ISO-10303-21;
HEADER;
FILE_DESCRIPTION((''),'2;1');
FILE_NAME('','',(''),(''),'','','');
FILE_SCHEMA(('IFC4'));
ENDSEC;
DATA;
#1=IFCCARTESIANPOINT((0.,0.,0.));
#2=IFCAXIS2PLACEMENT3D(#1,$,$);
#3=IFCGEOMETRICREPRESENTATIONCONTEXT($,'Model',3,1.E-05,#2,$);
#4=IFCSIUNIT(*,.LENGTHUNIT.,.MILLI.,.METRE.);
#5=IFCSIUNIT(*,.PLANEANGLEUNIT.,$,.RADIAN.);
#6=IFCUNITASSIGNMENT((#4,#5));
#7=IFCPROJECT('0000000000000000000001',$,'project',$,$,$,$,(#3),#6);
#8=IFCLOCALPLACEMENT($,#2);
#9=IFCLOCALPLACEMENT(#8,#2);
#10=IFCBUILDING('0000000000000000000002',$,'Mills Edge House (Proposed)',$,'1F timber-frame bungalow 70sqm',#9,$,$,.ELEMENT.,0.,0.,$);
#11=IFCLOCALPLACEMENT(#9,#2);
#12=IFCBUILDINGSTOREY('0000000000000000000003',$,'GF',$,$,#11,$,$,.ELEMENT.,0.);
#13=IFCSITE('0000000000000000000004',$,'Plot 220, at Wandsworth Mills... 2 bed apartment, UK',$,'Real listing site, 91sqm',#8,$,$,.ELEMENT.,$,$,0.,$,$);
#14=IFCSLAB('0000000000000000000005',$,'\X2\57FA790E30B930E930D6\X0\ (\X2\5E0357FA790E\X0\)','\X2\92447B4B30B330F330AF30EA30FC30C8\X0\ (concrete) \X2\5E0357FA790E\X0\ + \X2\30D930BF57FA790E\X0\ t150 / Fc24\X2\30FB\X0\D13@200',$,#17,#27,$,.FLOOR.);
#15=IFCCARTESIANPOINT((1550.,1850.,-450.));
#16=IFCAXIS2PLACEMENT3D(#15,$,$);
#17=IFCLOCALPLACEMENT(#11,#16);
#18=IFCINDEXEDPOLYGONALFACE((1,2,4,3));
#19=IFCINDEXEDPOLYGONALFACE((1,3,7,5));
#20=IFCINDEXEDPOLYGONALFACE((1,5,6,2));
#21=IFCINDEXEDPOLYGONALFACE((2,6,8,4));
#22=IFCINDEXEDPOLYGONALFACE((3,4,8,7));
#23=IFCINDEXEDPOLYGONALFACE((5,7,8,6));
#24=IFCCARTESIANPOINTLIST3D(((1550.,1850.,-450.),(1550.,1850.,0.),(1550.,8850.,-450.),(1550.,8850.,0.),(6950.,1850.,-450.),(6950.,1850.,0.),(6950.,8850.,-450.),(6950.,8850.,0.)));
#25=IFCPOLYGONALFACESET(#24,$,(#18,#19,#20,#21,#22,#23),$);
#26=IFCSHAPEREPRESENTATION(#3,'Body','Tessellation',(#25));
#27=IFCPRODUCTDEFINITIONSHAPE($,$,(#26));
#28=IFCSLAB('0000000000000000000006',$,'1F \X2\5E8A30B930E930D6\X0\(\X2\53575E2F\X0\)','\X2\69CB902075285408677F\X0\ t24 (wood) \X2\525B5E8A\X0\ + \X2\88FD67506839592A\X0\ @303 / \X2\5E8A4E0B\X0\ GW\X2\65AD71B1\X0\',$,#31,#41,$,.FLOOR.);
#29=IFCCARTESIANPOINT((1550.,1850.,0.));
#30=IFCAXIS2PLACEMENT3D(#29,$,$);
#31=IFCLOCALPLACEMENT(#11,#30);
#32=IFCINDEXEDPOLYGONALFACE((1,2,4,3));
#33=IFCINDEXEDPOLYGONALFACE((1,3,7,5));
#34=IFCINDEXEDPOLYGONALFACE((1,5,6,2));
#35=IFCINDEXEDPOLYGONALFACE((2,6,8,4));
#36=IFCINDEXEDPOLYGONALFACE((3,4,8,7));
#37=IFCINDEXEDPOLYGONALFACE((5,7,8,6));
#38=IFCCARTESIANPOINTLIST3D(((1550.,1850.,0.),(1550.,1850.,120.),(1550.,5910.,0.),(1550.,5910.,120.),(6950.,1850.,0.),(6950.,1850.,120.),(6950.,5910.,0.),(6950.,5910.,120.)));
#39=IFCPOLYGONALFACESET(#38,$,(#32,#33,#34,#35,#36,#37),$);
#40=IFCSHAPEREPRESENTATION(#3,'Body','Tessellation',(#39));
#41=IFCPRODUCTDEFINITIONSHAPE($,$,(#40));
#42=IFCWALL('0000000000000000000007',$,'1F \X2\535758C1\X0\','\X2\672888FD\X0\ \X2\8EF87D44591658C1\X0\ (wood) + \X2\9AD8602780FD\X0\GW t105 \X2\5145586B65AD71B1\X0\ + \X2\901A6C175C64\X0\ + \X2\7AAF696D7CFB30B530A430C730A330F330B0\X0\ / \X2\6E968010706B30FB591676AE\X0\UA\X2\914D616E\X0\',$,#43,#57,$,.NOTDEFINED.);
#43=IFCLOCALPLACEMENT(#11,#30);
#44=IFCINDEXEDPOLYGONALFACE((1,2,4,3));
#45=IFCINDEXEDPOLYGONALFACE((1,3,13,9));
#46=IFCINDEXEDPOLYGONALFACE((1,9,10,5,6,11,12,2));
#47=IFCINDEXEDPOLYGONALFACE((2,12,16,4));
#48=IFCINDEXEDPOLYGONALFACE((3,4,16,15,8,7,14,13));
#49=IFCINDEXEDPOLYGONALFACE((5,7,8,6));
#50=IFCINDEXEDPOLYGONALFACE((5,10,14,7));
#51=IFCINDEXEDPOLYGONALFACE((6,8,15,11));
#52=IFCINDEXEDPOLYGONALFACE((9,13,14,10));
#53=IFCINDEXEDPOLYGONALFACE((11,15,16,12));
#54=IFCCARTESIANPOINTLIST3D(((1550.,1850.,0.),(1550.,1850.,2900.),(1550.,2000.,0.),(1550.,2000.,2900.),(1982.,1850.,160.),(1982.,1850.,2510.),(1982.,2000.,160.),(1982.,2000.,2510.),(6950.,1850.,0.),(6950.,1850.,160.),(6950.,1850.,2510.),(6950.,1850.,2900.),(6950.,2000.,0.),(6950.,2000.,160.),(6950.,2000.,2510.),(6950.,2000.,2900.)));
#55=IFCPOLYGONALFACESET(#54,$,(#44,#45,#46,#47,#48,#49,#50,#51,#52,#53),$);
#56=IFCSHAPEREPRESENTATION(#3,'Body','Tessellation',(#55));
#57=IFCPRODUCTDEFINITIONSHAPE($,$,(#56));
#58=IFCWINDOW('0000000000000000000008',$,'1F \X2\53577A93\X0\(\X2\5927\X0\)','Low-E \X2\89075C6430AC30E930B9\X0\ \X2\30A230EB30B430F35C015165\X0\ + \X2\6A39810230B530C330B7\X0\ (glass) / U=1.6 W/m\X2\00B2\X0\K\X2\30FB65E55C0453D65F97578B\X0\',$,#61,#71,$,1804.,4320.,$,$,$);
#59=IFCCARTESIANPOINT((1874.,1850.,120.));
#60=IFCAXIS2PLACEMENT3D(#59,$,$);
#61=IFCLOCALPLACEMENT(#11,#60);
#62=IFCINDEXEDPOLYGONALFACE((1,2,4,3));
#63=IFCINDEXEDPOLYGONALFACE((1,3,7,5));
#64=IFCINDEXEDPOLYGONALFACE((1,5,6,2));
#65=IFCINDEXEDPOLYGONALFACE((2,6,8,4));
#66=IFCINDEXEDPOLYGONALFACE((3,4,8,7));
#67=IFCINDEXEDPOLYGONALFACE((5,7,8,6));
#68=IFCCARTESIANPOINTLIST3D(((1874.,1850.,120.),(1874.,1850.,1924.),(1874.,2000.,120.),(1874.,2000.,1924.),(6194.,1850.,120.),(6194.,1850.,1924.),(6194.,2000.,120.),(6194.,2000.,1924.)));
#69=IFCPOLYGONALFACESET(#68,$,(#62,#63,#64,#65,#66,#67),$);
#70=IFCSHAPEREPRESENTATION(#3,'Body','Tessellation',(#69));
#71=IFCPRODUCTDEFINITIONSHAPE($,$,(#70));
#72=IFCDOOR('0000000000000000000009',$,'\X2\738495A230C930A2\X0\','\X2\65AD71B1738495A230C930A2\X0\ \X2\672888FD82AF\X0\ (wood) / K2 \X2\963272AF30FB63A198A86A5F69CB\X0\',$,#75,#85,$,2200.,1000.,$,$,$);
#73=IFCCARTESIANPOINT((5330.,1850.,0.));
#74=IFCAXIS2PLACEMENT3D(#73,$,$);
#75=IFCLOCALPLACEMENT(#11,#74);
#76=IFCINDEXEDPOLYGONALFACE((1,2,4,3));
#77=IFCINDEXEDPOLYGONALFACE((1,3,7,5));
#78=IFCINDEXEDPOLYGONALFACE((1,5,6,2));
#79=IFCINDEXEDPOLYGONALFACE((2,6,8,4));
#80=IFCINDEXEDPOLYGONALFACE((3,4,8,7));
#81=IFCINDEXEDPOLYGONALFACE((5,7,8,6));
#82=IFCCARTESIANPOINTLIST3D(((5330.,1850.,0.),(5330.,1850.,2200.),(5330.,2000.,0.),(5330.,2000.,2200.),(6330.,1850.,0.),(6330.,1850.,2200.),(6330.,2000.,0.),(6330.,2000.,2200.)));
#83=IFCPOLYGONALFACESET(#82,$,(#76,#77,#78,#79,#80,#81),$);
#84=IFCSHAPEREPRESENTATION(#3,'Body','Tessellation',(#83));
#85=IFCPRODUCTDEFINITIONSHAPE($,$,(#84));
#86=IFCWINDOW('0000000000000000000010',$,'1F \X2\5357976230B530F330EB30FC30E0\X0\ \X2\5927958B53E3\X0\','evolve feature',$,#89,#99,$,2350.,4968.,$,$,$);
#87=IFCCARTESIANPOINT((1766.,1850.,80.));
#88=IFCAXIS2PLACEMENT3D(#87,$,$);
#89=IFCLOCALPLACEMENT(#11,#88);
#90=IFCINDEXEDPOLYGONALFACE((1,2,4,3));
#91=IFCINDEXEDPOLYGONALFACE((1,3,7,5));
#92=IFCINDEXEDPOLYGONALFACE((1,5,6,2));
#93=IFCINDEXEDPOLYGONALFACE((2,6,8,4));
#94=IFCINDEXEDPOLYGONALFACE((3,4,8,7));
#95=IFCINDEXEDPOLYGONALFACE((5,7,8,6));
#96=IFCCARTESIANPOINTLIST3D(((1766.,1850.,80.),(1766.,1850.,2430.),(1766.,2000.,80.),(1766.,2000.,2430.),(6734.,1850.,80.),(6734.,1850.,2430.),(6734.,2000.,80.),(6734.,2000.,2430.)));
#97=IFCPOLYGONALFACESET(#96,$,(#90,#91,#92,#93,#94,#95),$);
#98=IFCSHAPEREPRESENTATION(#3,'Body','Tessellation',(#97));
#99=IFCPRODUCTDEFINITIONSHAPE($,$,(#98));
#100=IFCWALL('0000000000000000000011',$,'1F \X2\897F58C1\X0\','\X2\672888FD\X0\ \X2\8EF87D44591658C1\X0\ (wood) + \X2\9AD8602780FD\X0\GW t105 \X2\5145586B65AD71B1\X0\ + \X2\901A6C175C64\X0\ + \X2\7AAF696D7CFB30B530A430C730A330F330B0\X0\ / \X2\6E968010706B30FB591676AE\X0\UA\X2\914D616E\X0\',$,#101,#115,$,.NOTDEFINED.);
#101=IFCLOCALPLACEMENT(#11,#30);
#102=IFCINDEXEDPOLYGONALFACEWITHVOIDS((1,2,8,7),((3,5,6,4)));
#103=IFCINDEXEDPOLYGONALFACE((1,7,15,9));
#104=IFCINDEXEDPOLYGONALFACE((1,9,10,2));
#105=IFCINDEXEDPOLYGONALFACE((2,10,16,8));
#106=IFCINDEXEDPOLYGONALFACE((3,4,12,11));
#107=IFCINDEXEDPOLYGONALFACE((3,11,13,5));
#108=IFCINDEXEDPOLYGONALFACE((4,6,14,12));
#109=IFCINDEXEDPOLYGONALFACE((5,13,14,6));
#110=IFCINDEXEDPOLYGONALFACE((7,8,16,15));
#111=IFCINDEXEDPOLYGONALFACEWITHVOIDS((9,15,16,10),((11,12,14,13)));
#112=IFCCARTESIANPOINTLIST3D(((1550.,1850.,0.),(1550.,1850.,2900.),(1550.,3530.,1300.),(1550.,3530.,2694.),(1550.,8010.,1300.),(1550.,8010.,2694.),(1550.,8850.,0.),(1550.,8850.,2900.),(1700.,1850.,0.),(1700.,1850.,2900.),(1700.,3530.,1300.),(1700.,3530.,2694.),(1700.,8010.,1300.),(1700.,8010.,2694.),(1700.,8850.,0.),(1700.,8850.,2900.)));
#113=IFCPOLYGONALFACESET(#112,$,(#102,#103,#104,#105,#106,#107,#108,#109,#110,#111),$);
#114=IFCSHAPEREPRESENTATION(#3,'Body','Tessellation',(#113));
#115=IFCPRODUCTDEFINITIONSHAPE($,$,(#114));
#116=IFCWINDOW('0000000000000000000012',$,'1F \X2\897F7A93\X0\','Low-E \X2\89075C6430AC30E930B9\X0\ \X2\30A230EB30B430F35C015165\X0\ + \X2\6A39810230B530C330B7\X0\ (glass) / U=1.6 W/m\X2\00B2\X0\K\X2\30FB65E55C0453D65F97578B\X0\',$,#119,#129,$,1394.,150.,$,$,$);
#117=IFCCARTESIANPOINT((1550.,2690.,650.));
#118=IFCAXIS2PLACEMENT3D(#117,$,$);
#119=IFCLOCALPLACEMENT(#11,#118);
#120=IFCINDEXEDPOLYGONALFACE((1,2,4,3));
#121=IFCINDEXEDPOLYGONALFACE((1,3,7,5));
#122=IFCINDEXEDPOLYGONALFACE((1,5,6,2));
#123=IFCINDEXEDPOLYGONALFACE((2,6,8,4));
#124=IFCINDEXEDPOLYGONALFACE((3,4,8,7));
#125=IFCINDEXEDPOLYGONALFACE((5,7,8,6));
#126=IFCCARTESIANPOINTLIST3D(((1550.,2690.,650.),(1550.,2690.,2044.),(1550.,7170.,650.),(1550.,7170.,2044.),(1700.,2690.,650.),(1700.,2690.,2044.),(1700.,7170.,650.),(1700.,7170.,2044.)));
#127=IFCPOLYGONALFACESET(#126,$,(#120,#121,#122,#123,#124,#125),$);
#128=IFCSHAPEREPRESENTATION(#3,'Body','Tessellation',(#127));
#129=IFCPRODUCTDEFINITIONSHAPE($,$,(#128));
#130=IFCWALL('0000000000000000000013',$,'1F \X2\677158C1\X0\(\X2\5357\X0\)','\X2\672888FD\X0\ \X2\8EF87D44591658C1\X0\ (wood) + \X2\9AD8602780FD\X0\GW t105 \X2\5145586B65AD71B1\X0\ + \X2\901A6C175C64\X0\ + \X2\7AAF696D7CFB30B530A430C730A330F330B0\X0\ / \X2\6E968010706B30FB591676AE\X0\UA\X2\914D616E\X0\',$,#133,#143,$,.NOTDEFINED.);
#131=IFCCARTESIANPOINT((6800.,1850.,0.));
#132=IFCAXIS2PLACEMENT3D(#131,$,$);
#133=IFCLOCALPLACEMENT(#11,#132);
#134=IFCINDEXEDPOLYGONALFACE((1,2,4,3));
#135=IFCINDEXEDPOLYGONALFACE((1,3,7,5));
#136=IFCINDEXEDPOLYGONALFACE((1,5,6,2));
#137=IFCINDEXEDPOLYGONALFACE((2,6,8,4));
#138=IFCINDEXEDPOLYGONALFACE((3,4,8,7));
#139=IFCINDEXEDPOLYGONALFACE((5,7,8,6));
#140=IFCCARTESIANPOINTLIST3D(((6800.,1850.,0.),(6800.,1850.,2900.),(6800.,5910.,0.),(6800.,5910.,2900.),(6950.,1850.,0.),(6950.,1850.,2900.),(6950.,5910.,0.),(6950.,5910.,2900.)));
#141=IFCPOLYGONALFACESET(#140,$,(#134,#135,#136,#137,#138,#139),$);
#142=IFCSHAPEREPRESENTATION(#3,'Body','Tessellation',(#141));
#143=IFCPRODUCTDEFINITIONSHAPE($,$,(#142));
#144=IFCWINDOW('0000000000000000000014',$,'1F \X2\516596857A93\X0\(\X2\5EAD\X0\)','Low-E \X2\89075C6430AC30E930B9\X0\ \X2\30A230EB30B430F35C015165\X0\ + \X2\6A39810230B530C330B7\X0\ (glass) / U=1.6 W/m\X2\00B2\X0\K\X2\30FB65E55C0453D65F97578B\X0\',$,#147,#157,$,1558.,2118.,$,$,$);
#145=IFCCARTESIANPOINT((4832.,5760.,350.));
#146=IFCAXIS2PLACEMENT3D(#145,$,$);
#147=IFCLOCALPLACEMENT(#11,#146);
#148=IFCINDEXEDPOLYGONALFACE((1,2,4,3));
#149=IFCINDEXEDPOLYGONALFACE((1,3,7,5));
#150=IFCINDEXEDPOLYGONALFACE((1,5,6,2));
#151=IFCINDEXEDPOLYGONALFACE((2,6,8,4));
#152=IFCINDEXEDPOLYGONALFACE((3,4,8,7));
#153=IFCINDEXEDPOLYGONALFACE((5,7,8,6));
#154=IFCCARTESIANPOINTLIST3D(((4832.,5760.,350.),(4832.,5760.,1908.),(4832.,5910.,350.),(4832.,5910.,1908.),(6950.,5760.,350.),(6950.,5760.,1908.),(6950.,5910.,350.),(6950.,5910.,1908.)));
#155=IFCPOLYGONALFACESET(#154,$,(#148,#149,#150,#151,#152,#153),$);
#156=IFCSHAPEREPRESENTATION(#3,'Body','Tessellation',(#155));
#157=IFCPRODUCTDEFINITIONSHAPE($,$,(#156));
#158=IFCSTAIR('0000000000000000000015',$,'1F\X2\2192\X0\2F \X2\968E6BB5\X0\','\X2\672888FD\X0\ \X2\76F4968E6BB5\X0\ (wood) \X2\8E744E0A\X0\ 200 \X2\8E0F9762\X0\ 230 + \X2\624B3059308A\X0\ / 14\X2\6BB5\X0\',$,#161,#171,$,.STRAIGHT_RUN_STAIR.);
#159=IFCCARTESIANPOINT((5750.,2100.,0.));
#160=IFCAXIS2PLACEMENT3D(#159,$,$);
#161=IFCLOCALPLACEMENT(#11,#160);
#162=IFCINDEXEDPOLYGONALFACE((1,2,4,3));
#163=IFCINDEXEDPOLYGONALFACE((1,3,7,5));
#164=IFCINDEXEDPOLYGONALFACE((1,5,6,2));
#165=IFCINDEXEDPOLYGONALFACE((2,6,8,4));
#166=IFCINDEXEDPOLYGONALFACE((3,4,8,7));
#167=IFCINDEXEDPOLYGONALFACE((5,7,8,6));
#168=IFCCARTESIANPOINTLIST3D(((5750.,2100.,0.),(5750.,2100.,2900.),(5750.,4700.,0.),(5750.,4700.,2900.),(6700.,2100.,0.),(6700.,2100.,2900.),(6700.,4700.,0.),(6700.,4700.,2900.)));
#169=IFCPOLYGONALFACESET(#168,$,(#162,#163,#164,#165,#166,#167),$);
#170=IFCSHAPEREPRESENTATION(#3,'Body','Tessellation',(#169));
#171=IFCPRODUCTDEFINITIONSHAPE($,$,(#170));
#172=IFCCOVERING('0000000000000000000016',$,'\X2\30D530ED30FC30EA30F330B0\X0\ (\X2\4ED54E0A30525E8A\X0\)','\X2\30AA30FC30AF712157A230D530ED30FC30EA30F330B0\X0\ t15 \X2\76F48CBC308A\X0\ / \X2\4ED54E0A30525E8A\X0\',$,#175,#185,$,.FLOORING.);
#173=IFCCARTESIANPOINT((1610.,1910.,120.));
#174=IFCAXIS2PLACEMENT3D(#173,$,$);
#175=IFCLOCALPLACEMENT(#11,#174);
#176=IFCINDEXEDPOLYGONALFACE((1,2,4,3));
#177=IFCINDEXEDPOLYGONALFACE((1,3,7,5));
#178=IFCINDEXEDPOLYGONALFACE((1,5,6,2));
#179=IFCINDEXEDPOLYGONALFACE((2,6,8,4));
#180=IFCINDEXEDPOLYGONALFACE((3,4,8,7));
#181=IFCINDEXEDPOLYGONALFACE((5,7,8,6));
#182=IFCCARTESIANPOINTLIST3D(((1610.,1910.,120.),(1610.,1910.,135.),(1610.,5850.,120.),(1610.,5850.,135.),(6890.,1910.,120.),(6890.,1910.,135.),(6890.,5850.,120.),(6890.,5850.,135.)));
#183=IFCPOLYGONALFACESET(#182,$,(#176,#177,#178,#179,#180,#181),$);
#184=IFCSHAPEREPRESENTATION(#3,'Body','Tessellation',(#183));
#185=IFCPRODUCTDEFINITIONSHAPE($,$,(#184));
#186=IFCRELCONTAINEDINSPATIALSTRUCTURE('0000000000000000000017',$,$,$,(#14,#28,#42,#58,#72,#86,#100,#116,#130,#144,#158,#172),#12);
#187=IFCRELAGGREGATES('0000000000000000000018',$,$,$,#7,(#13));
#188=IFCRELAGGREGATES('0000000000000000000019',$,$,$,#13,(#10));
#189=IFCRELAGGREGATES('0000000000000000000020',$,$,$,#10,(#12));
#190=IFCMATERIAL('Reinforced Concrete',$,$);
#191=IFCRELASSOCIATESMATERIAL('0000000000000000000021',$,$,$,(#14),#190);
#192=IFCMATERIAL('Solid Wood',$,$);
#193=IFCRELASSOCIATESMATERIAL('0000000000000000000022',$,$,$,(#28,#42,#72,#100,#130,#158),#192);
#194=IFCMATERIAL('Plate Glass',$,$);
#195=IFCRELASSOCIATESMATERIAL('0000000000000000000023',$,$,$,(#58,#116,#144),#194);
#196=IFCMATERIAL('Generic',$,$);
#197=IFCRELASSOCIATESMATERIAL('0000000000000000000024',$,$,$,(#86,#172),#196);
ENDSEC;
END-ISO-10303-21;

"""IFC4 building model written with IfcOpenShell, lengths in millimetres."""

from ifc_helpers import new_model, si_unit, frame, frame_2d, origin, place, context, project, spatial, rectangle, extrude, material, element, fill, save


model = new_model("IFC4")

# Units and contexts
model_context = context("Model", 3, precision=1e-05, world=origin())
ifc_project = project(units=[si_unit("LENGTHUNIT", "METRE", prefix="MILLI"), si_unit("PLANEANGLEUNIT", "RADIAN")], contexts=[model_context])

# Site, building, storey
site_placement = place(None, origin())
site = spatial("IfcSite", under=ifc_project, at=site_placement, Name="Plot 220, at Wandsworth Mills... 2 bed apartment, UK", ObjectType="Real listing site, 91sqm", CompositionType="ELEMENT", RefElevation=0.0)
building_placement = place(site_placement, origin())
building = spatial("IfcBuilding", under=site, at=building_placement, Name="Mills Edge House (Proposed)", ObjectType="1F timber-frame bungalow 70sqm", CompositionType="ELEMENT", ElevationOfRefHeight=0.0, ElevationOfTerrain=0.0)
storey_placement = place(building_placement, origin())
storey = spatial("IfcBuildingStorey", under=building, at=storey_placement, Name="GF", CompositionType="ELEMENT", Elevation=0.0)

# Slabs
ifc_material_1 = material(Name="Reinforced Concrete")
slab_1_placement = place(storey_placement, frame((1550.0, 1850.0, -450.0)))
element("IfcSlab", 1, at=slab_1_placement, inside=storey, material=ifc_material_1, Name="基礎スラブ (布基礎)", Description="鉄筋コンクリート (concrete) 布基礎 + ベタ基礎 t150 / Fc24・D13@200", PredefinedType="FLOOR", context=model_context, shape_type="SweptSolid", body=[
    extrude(rectangle(XDim=5400.0, YDim=7000.0, at=frame_2d((2700.0, 3500.0))), frame((1550.0, 1850.0, -450.0)), (0.0, 0.0, 1.0), 450.0),
])
ifc_material_2 = material(Name="Solid Wood")
slab_2_placement = place(storey_placement, frame((1550.0, 1850.0, 0.0)))
element("IfcSlab", 2, at=slab_2_placement, inside=storey, material=ifc_material_2, Name="1F 床スラブ(南帯)", Description="構造用合板 t24 (wood) 剛床 + 製材根太 @303 / 床下 GW断熱", PredefinedType="FLOOR", context=model_context, shape_type="SweptSolid", body=[
    extrude(rectangle(XDim=5400.0, YDim=4060.0, at=frame_2d((2700.0, 2030.0))), frame((1550.0, 1850.0, 0.0)), (0.0, 0.0, 1.0), 120.0),
])

# Wall, openings, windows, door
wall_1_placement = place(storey_placement, frame((1550.0, 1850.0, 0.0)))
wall_1 = element("IfcWall", 3, at=wall_1_placement, inside=storey, material=ifc_material_2, Name="1F 南壁", Description="木製 軸組外壁 (wood) + 高性能GW t105 充填断熱 + 通気層 + 窯業系サイディング / 準耐火・外皮UA配慮", PredefinedType="NOTDEFINED", context=model_context, shape_type="SweptSolid", body=[
    extrude(rectangle(XDim=5400.0, YDim=150.0, at=frame_2d((2700.0, 75.0))), frame((1550.0, 1850.0, 0.0)), (0.0, 0.0, 1.0), 2900.0),
])
opening_1_placement = place(storey_placement, frame((1874.0, 1850.0, 120.0)))
opening_1 = element("IfcOpeningElement", 4, at=opening_1_placement, cuts=wall_1, PredefinedType="NOTDEFINED", context=model_context, shape_type="SweptSolid", body=[
    extrude(rectangle(XDim=4320.0, YDim=150.0, at=frame_2d((2160.0, 75.0))), frame((1874.0, 1850.0, 120.0)), (0.0, 0.0, 1.0), 1804.0),
])
opening_2_placement = place(storey_placement, frame((5330.0, 1850.0, 0.0)))
opening_2 = element("IfcOpeningElement", 5, at=opening_2_placement, cuts=wall_1, PredefinedType="NOTDEFINED", context=model_context, shape_type="SweptSolid", body=[
    extrude(rectangle(XDim=1000.0, YDim=150.0, at=frame_2d((500.0, 75.0))), frame((5330.0, 1850.0, 0.0)), (0.0, 0.0, 1.0), 2200.0),
])
opening_3_placement = place(storey_placement, frame((1766.0, 1850.0, 80.0)))
opening_3 = element("IfcOpeningElement", 6, at=opening_3_placement, cuts=wall_1, PredefinedType="NOTDEFINED", context=model_context, shape_type="SweptSolid", body=[
    extrude(rectangle(XDim=4968.0, YDim=150.0, at=frame_2d((2484.0, 75.0))), frame((1766.0, 1850.0, 80.0)), (0.0, 0.0, 1.0), 2350.0),
])
ifc_material_3 = material(Name="Plate Glass")
window_1_placement = place(storey_placement, frame((1874.0, 1850.0, 120.0)))
window_1 = element("IfcWindow", 7, at=window_1_placement, inside=storey, material=ifc_material_3, Name="1F 南窓(大)", Description="Low-E 複層ガラス アルゴン封入 + 樹脂サッシ (glass) / U=1.6 W/m²K・日射取得型", OverallHeight=1804.0, OverallWidth=4320.0, context=model_context, shape_type="SweptSolid", body=[
    extrude(rectangle(XDim=4320.0, YDim=150.0, at=frame_2d((2160.0, 75.0))), frame((1874.0, 1850.0, 120.0)), (0.0, 0.0, 1.0), 1804.0),
])
fill(opening_1, window_1)
door_1_placement = place(storey_placement, frame((5330.0, 1850.0, 0.0)))
door_1 = element("IfcDoor", 8, at=door_1_placement, inside=storey, material=ifc_material_2, Name="玄関ドア", Description="断熱玄関ドア 木製芯 (wood) / K2 防犯・採風機構", OverallHeight=2200.0, OverallWidth=1000.0, context=model_context, shape_type="SweptSolid", body=[
    extrude(rectangle(XDim=1000.0, YDim=150.0, at=frame_2d((500.0, 75.0))), frame((5330.0, 1850.0, 0.0)), (0.0, 0.0, 1.0), 2200.0),
])
fill(opening_2, door_1)
ifc_material_4 = material(Name="Generic")
window_2_placement = place(storey_placement, frame((1766.0, 1850.0, 80.0)))
window_2 = element("IfcWindow", 9, at=window_2_placement, inside=storey, material=ifc_material_4, Name="1F 南面サンルーム 大開口", Description="evolve feature", OverallHeight=2350.0, OverallWidth=4968.0, context=model_context, shape_type="SweptSolid", body=[
    extrude(rectangle(XDim=4968.0, YDim=150.0, at=frame_2d((2484.0, 75.0))), frame((1766.0, 1850.0, 80.0)), (0.0, 0.0, 1.0), 2350.0),
])
fill(opening_3, window_2)

# Walls, openings, windows
wall_2_placement = place(storey_placement, frame((1550.0, 1850.0, 0.0)))
wall_2 = element("IfcWall", 10, at=wall_2_placement, inside=storey, material=ifc_material_2, Name="1F 西壁", Description="木製 軸組外壁 (wood) + 高性能GW t105 充填断熱 + 通気層 + 窯業系サイディング / 準耐火・外皮UA配慮", PredefinedType="NOTDEFINED", context=model_context, shape_type="SweptSolid", body=[
    extrude(rectangle(XDim=150.0, YDim=7000.0, at=frame_2d((75.0, 3500.0))), frame((1550.0, 1850.0, 0.0)), (0.0, 0.0, 1.0), 2900.0),
])
opening_4_placement = place(storey_placement, frame((1550.0, 2690.0, 650.0)))
opening_4 = element("IfcOpeningElement", 11, at=opening_4_placement, cuts=wall_2, PredefinedType="NOTDEFINED", context=model_context, shape_type="SweptSolid", body=[
    extrude(rectangle(XDim=150.0, YDim=4480.0, at=frame_2d((75.0, 2240.0))), frame((1550.0, 2690.0, 650.0)), (0.0, 0.0, 1.0), 1394.0),
])
window_3_placement = place(storey_placement, frame((1550.0, 2690.0, 650.0)))
window_3 = element("IfcWindow", 12, at=window_3_placement, inside=storey, material=ifc_material_3, Name="1F 西窓", Description="Low-E 複層ガラス アルゴン封入 + 樹脂サッシ (glass) / U=1.6 W/m²K・日射取得型", OverallHeight=1394.0, OverallWidth=150.0, context=model_context, shape_type="SweptSolid", body=[
    extrude(rectangle(XDim=150.0, YDim=4480.0, at=frame_2d((75.0, 2240.0))), frame((1550.0, 2690.0, 650.0)), (0.0, 0.0, 1.0), 1394.0),
])
fill(opening_4, window_3)
wall_3_placement = place(storey_placement, frame((6800.0, 1850.0, 0.0)))
wall_3 = element("IfcWall", 13, at=wall_3_placement, inside=storey, material=ifc_material_2, Name="1F 東壁(南)", Description="木製 軸組外壁 (wood) + 高性能GW t105 充填断熱 + 通気層 + 窯業系サイディング / 準耐火・外皮UA配慮", PredefinedType="NOTDEFINED", context=model_context, shape_type="SweptSolid", body=[
    extrude(rectangle(XDim=150.0, YDim=4060.0, at=frame_2d((75.0, 2030.0))), frame((6800.0, 1850.0, 0.0)), (0.0, 0.0, 1.0), 2900.0),
])
opening_5_placement = place(storey_placement, frame((4832.0, 5760.0, 350.0)))
opening_5 = element("IfcOpeningElement", 14, at=opening_5_placement, cuts=wall_3, PredefinedType="NOTDEFINED", context=model_context, shape_type="SweptSolid", body=[
    extrude(rectangle(XDim=2118.0, YDim=150.0, at=frame_2d((1059.0, 75.0))), frame((4832.0, 5760.0, 350.0)), (0.0, 0.0, 1.0), 1558.0),
])
window_4_placement = place(storey_placement, frame((4832.0, 5760.0, 350.0)))
window_4 = element("IfcWindow", 15, at=window_4_placement, inside=storey, material=ifc_material_3, Name="1F 入隅窓(庭)", Description="Low-E 複層ガラス アルゴン封入 + 樹脂サッシ (glass) / U=1.6 W/m²K・日射取得型", OverallHeight=1558.0, OverallWidth=2118.0, context=model_context, shape_type="SweptSolid", body=[
    extrude(rectangle(XDim=2118.0, YDim=150.0, at=frame_2d((1059.0, 75.0))), frame((4832.0, 5760.0, 350.0)), (0.0, 0.0, 1.0), 1558.0),
])
fill(opening_5, window_4)

# Stair
stair_placement = place(storey_placement, frame((5750.0, 2100.0, 0.0)))
element("IfcStair", 16, at=stair_placement, inside=storey, material=ifc_material_2, Name="1F→2F 階段", Description="木製 直階段 (wood) 蹴上 200 踏面 230 + 手すり / 14段", PredefinedType="STRAIGHT_RUN_STAIR", context=model_context, shape_type="SweptSolid", body=[
    extrude(rectangle(XDim=950.0, YDim=2600.0, at=frame_2d((475.0, 1300.0))), frame((5750.0, 2100.0, 0.0)), (0.0, 0.0, 1.0), 2900.0),
])

# Covering
covering_placement = place(storey_placement, frame((1610.0, 1910.0, 120.0)))
element("IfcCovering", 17, at=covering_placement, inside=storey, material=ifc_material_4, Name="フローリング (仕上げ床)", Description="オーク無垢フローリング t15 直貼り / 仕上げ床", PredefinedType="FLOORING", context=model_context, shape_type="SweptSolid", body=[
    extrude(rectangle(XDim=5280.0, YDim=3940.0, at=frame_2d((2640.0, 1970.0))), frame((1610.0, 1910.0, 120.0)), (0.0, 0.0, 1.0), 15.0),
])

save(model, "model.ifc")
